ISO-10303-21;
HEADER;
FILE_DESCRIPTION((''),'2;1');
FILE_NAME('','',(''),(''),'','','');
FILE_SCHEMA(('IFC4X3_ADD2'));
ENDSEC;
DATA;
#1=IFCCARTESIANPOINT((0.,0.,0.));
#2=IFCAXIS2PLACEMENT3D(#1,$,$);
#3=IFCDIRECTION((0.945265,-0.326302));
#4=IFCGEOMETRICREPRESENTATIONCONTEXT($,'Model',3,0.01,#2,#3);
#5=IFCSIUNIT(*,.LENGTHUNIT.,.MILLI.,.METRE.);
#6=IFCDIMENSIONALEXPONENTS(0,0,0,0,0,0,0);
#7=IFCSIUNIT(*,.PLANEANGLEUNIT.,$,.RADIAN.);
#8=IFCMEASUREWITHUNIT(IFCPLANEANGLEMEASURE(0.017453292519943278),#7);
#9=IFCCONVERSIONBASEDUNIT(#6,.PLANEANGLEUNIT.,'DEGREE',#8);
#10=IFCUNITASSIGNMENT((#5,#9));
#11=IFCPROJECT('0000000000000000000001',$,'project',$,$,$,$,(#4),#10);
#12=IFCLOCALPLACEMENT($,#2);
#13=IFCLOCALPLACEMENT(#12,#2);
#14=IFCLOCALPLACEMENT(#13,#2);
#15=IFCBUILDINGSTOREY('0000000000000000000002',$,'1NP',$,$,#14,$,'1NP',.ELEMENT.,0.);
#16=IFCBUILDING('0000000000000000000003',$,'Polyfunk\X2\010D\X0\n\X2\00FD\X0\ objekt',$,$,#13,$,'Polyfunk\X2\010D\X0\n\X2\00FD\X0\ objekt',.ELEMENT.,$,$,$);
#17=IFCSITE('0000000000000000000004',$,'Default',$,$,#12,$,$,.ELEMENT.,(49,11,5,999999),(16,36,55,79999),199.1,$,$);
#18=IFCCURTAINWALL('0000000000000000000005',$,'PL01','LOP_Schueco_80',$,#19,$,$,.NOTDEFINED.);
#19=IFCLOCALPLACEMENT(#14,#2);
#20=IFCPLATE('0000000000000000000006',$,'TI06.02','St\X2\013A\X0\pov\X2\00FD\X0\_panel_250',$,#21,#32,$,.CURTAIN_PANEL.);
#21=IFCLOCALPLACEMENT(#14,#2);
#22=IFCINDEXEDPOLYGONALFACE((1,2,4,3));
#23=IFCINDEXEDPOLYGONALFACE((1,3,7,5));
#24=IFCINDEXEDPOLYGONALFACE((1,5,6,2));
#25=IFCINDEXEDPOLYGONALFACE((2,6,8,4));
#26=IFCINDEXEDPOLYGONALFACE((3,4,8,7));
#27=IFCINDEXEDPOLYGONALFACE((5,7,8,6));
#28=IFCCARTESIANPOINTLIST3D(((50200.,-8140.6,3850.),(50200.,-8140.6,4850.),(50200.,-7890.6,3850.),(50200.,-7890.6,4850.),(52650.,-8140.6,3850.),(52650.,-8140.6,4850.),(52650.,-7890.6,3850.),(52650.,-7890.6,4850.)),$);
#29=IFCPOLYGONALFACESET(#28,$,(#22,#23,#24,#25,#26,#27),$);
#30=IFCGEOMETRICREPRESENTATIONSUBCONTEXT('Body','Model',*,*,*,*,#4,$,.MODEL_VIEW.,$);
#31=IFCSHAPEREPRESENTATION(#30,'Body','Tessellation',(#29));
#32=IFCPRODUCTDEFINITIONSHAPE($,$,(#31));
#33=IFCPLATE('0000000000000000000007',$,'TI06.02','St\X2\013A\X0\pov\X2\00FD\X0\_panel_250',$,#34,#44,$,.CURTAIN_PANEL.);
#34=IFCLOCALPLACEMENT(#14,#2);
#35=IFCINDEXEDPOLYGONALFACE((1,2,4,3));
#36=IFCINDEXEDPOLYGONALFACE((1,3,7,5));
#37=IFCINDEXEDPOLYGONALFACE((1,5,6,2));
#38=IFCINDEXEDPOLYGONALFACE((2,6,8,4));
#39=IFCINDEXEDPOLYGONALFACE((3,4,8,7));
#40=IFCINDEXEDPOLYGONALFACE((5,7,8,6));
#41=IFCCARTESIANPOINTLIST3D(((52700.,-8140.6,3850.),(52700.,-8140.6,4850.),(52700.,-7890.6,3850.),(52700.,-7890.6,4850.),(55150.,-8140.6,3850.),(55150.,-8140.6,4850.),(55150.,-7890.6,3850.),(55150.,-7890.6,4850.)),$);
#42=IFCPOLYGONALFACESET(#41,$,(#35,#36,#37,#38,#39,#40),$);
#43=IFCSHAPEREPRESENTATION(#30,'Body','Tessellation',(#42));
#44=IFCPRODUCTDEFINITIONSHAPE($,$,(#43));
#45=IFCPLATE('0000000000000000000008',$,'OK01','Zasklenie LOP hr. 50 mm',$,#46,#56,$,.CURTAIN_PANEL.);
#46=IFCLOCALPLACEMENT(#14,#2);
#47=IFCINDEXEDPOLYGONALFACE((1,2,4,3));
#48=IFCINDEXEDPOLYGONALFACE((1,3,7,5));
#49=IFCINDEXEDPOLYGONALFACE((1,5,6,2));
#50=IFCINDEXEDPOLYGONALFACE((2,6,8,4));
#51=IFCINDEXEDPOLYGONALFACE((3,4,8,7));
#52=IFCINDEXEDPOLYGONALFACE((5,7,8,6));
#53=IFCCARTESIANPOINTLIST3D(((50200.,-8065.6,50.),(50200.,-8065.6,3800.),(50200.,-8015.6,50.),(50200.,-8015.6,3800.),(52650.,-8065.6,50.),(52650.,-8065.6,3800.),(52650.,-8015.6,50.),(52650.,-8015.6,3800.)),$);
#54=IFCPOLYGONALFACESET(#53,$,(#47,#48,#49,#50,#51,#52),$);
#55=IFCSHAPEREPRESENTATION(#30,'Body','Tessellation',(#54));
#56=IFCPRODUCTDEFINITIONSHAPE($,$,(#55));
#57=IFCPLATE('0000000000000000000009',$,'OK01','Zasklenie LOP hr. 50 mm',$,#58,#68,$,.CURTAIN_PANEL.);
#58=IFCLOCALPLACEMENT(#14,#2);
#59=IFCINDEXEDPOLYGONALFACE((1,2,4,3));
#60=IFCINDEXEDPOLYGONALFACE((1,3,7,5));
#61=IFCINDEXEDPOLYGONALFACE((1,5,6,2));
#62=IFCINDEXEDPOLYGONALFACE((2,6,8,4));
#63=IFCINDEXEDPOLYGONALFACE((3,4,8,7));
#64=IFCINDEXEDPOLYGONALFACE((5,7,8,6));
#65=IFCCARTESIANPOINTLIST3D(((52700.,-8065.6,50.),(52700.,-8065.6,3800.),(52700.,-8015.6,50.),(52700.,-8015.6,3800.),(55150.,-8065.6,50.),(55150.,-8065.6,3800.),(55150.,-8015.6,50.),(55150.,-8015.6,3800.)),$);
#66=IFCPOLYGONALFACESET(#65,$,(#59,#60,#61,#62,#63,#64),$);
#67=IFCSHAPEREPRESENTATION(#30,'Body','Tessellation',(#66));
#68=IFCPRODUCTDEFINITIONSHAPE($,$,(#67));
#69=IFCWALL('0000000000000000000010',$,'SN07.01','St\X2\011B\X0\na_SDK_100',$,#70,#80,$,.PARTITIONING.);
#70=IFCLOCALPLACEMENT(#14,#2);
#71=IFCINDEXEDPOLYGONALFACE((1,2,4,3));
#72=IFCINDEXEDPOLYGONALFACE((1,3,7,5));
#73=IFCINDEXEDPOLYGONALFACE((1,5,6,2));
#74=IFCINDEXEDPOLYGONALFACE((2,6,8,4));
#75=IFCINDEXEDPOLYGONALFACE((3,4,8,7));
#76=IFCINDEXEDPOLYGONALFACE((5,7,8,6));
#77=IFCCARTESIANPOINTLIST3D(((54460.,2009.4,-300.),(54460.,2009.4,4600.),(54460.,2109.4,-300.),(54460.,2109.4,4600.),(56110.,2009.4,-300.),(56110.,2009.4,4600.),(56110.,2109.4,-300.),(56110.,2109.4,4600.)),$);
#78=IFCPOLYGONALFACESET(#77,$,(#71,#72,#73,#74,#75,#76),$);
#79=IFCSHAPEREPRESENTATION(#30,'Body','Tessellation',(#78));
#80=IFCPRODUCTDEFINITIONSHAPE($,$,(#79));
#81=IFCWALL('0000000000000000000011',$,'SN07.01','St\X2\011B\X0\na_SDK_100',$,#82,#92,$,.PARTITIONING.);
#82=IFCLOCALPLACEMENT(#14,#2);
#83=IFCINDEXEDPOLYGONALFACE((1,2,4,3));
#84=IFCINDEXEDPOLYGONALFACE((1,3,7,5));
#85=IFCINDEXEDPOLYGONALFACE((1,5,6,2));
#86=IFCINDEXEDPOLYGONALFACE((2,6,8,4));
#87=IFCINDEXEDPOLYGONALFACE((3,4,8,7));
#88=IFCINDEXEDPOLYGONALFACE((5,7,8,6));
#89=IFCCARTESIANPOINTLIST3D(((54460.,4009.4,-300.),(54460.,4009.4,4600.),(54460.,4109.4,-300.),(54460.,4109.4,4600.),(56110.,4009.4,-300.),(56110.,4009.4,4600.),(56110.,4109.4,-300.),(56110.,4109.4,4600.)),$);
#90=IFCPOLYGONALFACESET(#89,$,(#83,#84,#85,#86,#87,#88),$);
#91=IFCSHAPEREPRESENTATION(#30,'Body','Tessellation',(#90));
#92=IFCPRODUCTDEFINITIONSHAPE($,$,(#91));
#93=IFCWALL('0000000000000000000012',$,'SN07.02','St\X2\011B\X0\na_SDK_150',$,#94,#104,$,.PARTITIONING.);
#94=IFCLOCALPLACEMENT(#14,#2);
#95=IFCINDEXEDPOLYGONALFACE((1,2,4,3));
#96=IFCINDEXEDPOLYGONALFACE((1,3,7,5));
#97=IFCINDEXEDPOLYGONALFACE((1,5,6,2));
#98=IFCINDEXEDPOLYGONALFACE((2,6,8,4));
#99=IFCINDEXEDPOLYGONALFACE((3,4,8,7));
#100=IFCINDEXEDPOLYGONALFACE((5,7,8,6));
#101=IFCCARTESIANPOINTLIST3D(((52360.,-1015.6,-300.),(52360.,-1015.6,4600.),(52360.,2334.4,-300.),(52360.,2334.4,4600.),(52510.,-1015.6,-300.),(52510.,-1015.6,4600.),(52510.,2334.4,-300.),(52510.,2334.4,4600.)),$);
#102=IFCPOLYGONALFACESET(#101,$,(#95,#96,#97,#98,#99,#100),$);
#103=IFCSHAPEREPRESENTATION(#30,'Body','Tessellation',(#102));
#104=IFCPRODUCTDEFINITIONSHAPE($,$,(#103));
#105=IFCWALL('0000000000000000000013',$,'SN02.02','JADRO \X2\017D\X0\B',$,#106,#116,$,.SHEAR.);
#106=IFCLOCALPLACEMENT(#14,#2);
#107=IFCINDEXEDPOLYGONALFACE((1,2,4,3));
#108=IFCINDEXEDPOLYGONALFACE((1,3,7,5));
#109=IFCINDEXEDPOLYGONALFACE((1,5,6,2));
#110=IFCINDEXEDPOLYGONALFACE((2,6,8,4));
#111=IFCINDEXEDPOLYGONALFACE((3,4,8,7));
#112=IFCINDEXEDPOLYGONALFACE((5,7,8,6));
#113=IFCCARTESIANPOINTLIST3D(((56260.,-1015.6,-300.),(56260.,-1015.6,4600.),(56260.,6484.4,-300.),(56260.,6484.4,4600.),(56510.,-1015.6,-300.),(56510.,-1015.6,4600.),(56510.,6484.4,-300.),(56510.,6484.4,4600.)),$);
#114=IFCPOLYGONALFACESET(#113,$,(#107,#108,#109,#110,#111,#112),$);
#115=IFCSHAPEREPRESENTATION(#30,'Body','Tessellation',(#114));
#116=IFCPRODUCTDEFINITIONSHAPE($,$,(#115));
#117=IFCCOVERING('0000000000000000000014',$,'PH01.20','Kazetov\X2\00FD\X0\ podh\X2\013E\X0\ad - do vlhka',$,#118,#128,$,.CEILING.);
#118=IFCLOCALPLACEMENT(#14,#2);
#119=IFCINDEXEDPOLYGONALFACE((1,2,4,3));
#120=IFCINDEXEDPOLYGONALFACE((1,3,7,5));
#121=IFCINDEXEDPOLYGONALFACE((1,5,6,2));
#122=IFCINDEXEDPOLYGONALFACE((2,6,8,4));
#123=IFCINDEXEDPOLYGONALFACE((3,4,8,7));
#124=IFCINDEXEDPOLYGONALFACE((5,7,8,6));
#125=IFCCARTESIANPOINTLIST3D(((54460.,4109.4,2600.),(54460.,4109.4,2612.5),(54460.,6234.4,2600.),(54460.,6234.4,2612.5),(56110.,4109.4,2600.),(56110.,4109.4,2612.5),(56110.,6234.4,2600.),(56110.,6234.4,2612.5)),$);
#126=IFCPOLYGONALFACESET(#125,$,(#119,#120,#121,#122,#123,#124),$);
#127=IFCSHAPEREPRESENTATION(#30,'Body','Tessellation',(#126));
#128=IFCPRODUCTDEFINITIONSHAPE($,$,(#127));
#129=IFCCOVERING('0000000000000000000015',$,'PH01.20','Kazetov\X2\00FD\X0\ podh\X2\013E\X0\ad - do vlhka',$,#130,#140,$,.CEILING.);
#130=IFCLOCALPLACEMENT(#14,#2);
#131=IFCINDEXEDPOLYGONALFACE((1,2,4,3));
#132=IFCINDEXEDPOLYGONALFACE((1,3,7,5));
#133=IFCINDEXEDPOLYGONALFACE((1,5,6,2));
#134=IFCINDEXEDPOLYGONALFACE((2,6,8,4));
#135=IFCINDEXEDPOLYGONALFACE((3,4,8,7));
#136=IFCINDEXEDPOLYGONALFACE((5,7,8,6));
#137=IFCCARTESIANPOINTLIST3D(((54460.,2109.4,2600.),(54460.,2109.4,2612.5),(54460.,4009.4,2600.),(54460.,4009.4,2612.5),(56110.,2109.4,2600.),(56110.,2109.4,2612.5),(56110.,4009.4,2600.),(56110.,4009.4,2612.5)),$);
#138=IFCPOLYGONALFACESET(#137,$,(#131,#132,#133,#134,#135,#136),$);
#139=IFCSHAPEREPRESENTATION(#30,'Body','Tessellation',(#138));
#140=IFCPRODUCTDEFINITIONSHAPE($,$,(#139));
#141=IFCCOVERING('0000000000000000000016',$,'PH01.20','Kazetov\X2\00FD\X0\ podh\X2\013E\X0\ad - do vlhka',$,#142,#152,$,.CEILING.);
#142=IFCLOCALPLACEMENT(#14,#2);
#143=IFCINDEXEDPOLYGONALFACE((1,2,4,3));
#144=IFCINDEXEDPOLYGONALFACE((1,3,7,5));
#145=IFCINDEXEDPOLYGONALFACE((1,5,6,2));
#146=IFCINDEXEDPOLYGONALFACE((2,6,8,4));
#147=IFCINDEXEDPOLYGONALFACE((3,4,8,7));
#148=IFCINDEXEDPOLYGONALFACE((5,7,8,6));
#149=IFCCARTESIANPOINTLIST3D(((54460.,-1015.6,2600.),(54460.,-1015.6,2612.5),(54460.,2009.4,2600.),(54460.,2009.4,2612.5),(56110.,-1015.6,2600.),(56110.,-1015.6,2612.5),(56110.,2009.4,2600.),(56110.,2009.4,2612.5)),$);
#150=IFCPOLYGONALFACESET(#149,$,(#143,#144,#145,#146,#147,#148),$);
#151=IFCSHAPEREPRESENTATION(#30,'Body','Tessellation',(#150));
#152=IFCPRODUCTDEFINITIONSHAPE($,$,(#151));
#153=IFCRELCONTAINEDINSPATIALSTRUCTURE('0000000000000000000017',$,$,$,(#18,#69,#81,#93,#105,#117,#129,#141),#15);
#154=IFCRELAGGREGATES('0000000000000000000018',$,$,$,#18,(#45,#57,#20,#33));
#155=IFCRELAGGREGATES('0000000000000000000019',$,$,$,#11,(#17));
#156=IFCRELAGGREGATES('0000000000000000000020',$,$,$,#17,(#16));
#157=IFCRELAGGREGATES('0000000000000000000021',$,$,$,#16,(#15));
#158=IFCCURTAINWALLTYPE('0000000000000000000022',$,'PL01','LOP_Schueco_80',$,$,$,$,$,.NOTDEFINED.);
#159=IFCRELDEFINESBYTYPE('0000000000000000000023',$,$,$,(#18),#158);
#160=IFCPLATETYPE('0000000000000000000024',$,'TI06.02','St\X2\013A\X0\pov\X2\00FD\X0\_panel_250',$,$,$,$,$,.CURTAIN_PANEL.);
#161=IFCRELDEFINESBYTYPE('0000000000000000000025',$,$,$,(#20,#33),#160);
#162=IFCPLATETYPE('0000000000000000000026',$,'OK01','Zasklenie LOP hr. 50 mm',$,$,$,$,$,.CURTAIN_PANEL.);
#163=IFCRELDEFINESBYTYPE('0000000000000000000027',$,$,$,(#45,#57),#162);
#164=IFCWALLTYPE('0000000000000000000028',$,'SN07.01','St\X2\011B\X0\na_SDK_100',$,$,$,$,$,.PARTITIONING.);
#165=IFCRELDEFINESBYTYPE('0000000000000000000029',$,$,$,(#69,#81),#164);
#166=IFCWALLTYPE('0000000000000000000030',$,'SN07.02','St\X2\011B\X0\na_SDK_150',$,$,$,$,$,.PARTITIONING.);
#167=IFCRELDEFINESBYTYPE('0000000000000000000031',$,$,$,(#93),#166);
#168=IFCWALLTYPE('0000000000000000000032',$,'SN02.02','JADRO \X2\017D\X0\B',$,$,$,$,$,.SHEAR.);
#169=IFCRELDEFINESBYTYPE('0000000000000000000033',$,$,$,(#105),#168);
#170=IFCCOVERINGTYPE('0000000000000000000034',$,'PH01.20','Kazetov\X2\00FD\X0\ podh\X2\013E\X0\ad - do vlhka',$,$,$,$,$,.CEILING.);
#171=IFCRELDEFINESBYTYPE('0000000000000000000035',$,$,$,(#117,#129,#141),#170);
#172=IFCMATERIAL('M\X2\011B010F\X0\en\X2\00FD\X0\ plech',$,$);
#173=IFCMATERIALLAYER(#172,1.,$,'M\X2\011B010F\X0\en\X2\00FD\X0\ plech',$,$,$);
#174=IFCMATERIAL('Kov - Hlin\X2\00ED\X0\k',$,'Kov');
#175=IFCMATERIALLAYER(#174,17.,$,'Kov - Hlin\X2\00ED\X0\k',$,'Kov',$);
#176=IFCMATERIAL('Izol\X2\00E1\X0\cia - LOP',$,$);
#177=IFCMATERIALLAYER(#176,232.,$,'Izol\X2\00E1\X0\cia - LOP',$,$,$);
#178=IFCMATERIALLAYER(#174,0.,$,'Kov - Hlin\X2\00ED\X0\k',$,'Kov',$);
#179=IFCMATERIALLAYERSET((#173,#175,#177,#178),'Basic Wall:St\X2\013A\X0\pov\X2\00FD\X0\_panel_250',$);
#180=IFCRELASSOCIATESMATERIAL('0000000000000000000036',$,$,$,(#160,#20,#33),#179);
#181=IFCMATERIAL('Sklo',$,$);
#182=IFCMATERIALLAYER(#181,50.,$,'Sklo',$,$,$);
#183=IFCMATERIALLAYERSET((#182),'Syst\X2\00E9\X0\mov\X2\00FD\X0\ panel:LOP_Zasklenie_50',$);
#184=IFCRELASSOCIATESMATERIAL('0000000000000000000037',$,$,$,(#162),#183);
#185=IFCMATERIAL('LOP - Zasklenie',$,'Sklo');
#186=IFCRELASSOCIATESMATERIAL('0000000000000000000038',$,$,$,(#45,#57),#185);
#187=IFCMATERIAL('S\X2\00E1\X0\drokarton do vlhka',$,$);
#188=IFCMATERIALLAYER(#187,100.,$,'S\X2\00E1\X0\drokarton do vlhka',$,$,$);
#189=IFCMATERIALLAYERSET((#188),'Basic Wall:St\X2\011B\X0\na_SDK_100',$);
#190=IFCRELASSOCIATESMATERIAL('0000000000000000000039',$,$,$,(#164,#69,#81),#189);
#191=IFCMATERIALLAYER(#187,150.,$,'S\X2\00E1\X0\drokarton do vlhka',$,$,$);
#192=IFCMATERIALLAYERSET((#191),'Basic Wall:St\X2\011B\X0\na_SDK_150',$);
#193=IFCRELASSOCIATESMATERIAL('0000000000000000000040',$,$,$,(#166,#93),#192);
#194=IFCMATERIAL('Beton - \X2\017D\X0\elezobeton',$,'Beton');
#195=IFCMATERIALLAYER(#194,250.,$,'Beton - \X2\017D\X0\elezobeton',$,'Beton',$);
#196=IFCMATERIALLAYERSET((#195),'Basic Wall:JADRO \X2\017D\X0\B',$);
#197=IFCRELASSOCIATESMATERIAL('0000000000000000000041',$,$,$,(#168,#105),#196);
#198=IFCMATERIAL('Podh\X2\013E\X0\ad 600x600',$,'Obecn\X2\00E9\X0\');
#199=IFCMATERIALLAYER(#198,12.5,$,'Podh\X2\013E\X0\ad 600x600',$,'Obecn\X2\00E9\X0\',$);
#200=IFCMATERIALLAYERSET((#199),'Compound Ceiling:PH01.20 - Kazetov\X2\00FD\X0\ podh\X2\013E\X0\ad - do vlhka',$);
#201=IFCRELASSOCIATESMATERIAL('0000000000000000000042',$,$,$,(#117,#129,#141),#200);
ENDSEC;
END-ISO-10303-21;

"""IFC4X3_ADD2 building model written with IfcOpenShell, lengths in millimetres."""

from ifc_helpers import new_model, entity, si_unit, converted_unit, direction, frame, frame_2d, origin, origin_2d_with_axis, place, context, subcontext, project, spatial, polyline, rectangle, extrude, clip, bounded_halfspace, source, transform, mapped, material, layer, layer_set, layer_usage, type_object, type_shapes, element, aggregate, save


model = new_model("IFC4X3_ADD2")

# Units and contexts
model_context = context("Model", 3, precision=0.01, world=origin(), true_north=direction((0.945265, -0.326302)))
body_context = subcontext(model_context, "Body", "Model", "MODEL_VIEW")
ifc_project = project(units=[si_unit("LENGTHUNIT", "METRE", prefix="MILLI"), converted_unit("PLANEANGLEUNIT", "DEGREE", entity("IfcPlaneAngleMeasure", 0.017453292519943278), si_unit("PLANEANGLEUNIT", "RADIAN"), dimensions=[0, 0, 0, 0, 0, 0, 0])], contexts=[model_context])

# Site, building, storey
site_placement = place(None, origin())
site = spatial("IfcSite", under=ifc_project, at=site_placement, Name="Default", CompositionType="ELEMENT", RefLatitude=(49, 11, 5, 999999), RefLongitude=(16, 36, 55, 79999), RefElevation=199.1)
building_placement = place(site_placement, origin())
building = spatial("IfcBuilding", under=site, at=building_placement, Name="Polyfunkčný objekt", LongName="Polyfunkčný objekt", CompositionType="ELEMENT")
storey_placement = place(building_placement, origin())
storey = spatial("IfcBuildingStorey", under=building, at=storey_placement, Name="1NP", LongName="1NP", CompositionType="ELEMENT", Elevation=0.0)

# Curtain wall, plates
curtain_wall_type = type_object("IfcCurtainWallType", Name="PL01", Description="LOP_Schueco_80", PredefinedType="NOTDEFINED")
curtain_wall_placement = place(storey_placement, origin())
curtain_wall = element("IfcCurtainWall", 1, at=curtain_wall_placement, inside=storey, type_object=curtain_wall_type, Name="PL01", Description="LOP_Schueco_80", PredefinedType="NOTDEFINED")
ifc_material_1 = material(Name="Měďený plech")
ifc_layer_1 = layer(ifc_material_1, 1.0, Name="Měďený plech")
ifc_material_2 = material(Name="Kov - Hliník", Category="Kov")
ifc_layer_2 = layer(ifc_material_2, 17.0, Name="Kov - Hliník", Category="Kov")
ifc_material_3 = material(Name="Izolácia - LOP")
ifc_layer_3 = layer(ifc_material_3, 232.0, Name="Izolácia - LOP")
ifc_layer_4 = layer(ifc_material_2, 0.0, Name="Kov - Hliník", Category="Kov")
ifc_layer_set_1 = layer_set([ifc_layer_1, ifc_layer_2, ifc_layer_3, ifc_layer_4], Name="Basic Wall:Stĺpový_panel_250")
ifc_layer_usage_1 = layer_usage(ifc_layer_set_1, "AXIS2", "POSITIVE", -125.0)
plate_type_1 = type_object("IfcPlateType", Name="TI06.02", Description="Stĺpový_panel_250", PredefinedType="CURTAIN_PANEL", material=ifc_layer_set_1)
plate_1_placement = place(storey_placement, frame((50200.0, -8015.6, 3850.0)))
plate_1 = element("IfcPlate", 2, at=plate_1_placement, type_object=plate_type_1, material=ifc_layer_usage_1, Name="TI06.02", Description="Stĺpový_panel_250", PredefinedType="CURTAIN_PANEL", context=body_context, shape_type="SweptSolid", body=[
    extrude(rectangle(XDim=250.0, YDim=2450.0, at=origin_2d_with_axis()), frame((1225.0, 0.0, 0.0), z_axis=(0.0, 0.0, 1.0), x_axis=(0.0, 1.0, 0.0)), (0.0, 0.0, 1.0), 1000.0),
])
ifc_layer_usage_2 = layer_usage(ifc_layer_set_1, "AXIS2", "POSITIVE", -125.0)
plate_2_placement = place(storey_placement, frame((52700.0, -8015.6, 3850.0)))
plate_2 = element("IfcPlate", 3, at=plate_2_placement, type_object=plate_type_1, material=ifc_layer_usage_2, Name="TI06.02", Description="Stĺpový_panel_250", PredefinedType="CURTAIN_PANEL", context=body_context, shape_type="SweptSolid", body=[
    extrude(rectangle(XDim=250.0, YDim=2450.0, at=frame_2d((0.0, 0.0), x_axis=(1.0, 0.0))), frame((1225.0, 0.0, 0.0), z_axis=(0.0, 0.0, 1.0), x_axis=(0.0, 1.0, 0.0)), (0.0, 0.0, 1.0), 1000.0),
])
ifc_material_4 = material(Name="LOP - Zasklenie", Category="Sklo")
ifc_material_5 = material(Name="Sklo")
ifc_layer_5 = layer(ifc_material_5, 50.0, Name="Sklo")
ifc_layer_set_2 = layer_set([ifc_layer_5], Name="Systémový panel:LOP_Zasklenie_50")
plate_type_2 = type_object("IfcPlateType", Name="OK01", Description="Zasklenie LOP hr. 50 mm", PredefinedType="CURTAIN_PANEL", material=ifc_layer_set_2)
shared_shape_1 = source(origin(), body_context, "Body", "SweptSolid", [
    extrude(rectangle(XDim=3750.0, YDim=2450.0, at=frame_2d((-331.2, 0.0), x_axis=(1.0, 0.0))), frame((0.0, -50.0, 2206.2), z_axis=(0.0, 1.0, 0.0), x_axis=(0.0, 0.0, 1.0)), (0.0, 0.0, 1.0), 50.0),
])
type_shapes(plate_type_2, [shared_shape_1])
plate_3_placement = place(curtain_wall_placement, frame((51425.0, -8015.6, 50.0)))
plate_3 = element("IfcPlate", 4, at=plate_3_placement, type_object=plate_type_2, material=ifc_material_4, Name="OK01", Description="Zasklenie LOP hr. 50 mm", PredefinedType="CURTAIN_PANEL", context=body_context, shape_type="MappedRepresentation", body=[
    mapped(shared_shape_1, transform((0.0, 0.0, 0.0), scale=1.0)),
])
plate_4_placement = place(curtain_wall_placement, frame((53925.0, -8015.6, 50.0)))
plate_4 = element("IfcPlate", 5, at=plate_4_placement, type_object=plate_type_2, material=ifc_material_4, Name="OK01", Description="Zasklenie LOP hr. 50 mm", PredefinedType="CURTAIN_PANEL", context=body_context, shape_type="MappedRepresentation", body=[
    mapped(shared_shape_1, transform((0.0, 0.0, 0.0), scale=1.0)),
])
aggregate(curtain_wall, [plate_3, plate_4, plate_1, plate_2])

# Walls
ifc_material_6 = material(Name="Sádrokarton do vlhka")
ifc_layer_6 = layer(ifc_material_6, 100.0, Name="Sádrokarton do vlhka")
ifc_layer_set_3 = layer_set([ifc_layer_6], Name="Basic Wall:Stěna_SDK_100")
wall_type_1 = type_object("IfcWallType", Name="SN07.01", Description="Stěna_SDK_100", PredefinedType="PARTITIONING", material=ifc_layer_set_3)
wall_1_placement = place(storey_placement, frame((54460.0, 2059.4, -300.0)))
element("IfcWall", 6, at=wall_1_placement, inside=storey, type_object=wall_type_1, material=ifc_layer_set_3, Name="SN07.01", Description="Stěna_SDK_100", PredefinedType="PARTITIONING", context=body_context, shape_type="Clipping", body=[
    clip(clip(extrude(rectangle(XDim=1650.0, YDim=100.0, at=frame_2d((825.0, 0.0), x_axis=(-1.0, 0.0))), origin(), (0.0, 0.0, 1.0), 4900.0), bounded_halfspace(frame((0.0, -50.0, 4900.0), z_axis=(0.0, 0.0, -1.0), x_axis=(1.0, 0.0, 0.0)), True, frame((0.0, -50.0, 4900.0)), polyline([(0.0, 0.0), (1650.0, 0.0), (1650.0, 100.0), (0.0, 100.0), (0.0, 0.0)]))), bounded_halfspace(frame((1650.0, -50.0, 0.0), z_axis=(0.0, 0.0, 1.0), x_axis=(0.0, 1.0, 0.0)), True, frame((1650.0, -50.0, 0.0)), polyline([(0.0, 0.0), (0.0, 100.0), (-1650.0, 100.0), (-1650.0, 0.0), (0.0, 0.0)]))),
])
wall_2_placement = place(storey_placement, frame((54460.0, 4059.4, -300.0)))
element("IfcWall", 7, at=wall_2_placement, inside=storey, type_object=wall_type_1, material=ifc_layer_set_3, Name="SN07.01", Description="Stěna_SDK_100", PredefinedType="PARTITIONING", context=body_context, shape_type="Clipping", body=[
    clip(clip(extrude(rectangle(XDim=1650.0, YDim=100.0, at=frame_2d((825.0, 0.0), x_axis=(-1.0, 0.0))), origin(), (0.0, 0.0, 1.0), 4900.0), bounded_halfspace(frame((0.0, -50.0, 4900.0), z_axis=(0.0, 0.0, -1.0), x_axis=(1.0, 0.0, 0.0)), True, frame((0.0, -50.0, 4900.0)), polyline([(0.0, 0.0), (1650.0, 0.0), (1650.0, 100.0), (0.0, 100.0), (0.0, 0.0)]))), bounded_halfspace(frame((1650.0, -50.0, 0.0), z_axis=(0.0, 0.0, 1.0), x_axis=(0.0, 1.0, 0.0)), True, frame((1650.0, -50.0, 0.0)), polyline([(0.0, 0.0), (0.0, 100.0), (-1650.0, 100.0), (-1650.0, 0.0), (0.0, 0.0)]))),
])
ifc_layer_7 = layer(ifc_material_6, 150.0, Name="Sádrokarton do vlhka")
ifc_layer_set_4 = layer_set([ifc_layer_7], Name="Basic Wall:Stěna_SDK_150")
wall_type_2 = type_object("IfcWallType", Name="SN07.02", Description="Stěna_SDK_150", PredefinedType="PARTITIONING", material=ifc_layer_set_4)
wall_3_placement = place(storey_placement, frame((52435.0, 2334.4, -300.0), z_axis=(0.0, 0.0, 1.0), x_axis=(0.0, -1.0, 0.0)))
element("IfcWall", 8, at=wall_3_placement, inside=storey, type_object=wall_type_2, material=ifc_layer_set_4, Name="SN07.02", Description="Stěna_SDK_150", PredefinedType="PARTITIONING", context=body_context, shape_type="Clipping", body=[
    clip(clip(extrude(rectangle(XDim=3350.0, YDim=150.0, at=frame_2d((1675.0, 0.0), x_axis=(-1.0, 0.0))), origin(), (0.0, 0.0, 1.0), 4900.0), bounded_halfspace(frame((3350.0, -75.0, 0.0), z_axis=(0.0, 0.0, 1.0), x_axis=(-1.0, 0.0, 0.0)), True, frame((3350.0, -75.0, 0.0)), polyline([(0.0, 0.0), (0.0, 150.0), (-3350.0, 150.0), (-3350.0, 0.0), (0.0, 0.0)]))), bounded_halfspace(frame((0.0, -75.0, 4900.0), z_axis=(0.0, 0.0, -1.0), x_axis=(0.0, 1.0, 0.0)), True, frame((0.0, -75.0, 4900.0)), polyline([(0.0, 0.0), (3350.0, 0.0), (3350.0, 150.0), (0.0, 150.0), (0.0, 0.0)]))),
])
ifc_material_7 = material(Name="Beton - Železobeton", Category="Beton")
ifc_layer_8 = layer(ifc_material_7, 250.0, Name="Beton - Železobeton", Category="Beton")
ifc_layer_set_5 = layer_set([ifc_layer_8], Name="Basic Wall:JADRO ŽB")
wall_type_3 = type_object("IfcWallType", Name="SN02.02", Description="JADRO ŽB", PredefinedType="SHEAR", material=ifc_layer_set_5)
wall_4_placement = place(storey_placement, frame((56385.0, -1015.6, -300.0), z_axis=(0.0, 0.0, 1.0), x_axis=(0.0, 1.0, 0.0)))
element("IfcWall", 9, at=wall_4_placement, inside=storey, type_object=wall_type_3, material=ifc_layer_set_5, Name="SN02.02", Description="JADRO ŽB", PredefinedType="SHEAR", context=body_context, shape_type="Clipping", body=[
    clip(clip(extrude(rectangle(XDim=7500.0, YDim=250.0, at=frame_2d((3750.0, 0.0), x_axis=(-1.0, 0.0))), origin(), (0.0, 0.0, 1.0), 4900.0), bounded_halfspace(frame((0.0, -125.0, 4900.0), z_axis=(0.0, 0.0, -1.0), x_axis=(0.0, -1.0, 0.0)), True, frame((0.0, -125.0, 4900.0)), polyline([(0.0, 0.0), (7500.0, 0.0), (7500.0, 250.0), (7250.0, 250.0), (0.0, 250.0), (0.0, 0.0)]))), bounded_halfspace(frame((0.0, -125.0, 0.0)), True, frame((0.0, -125.0, 0.0)), polyline([(0.0, 0.0), (7110.0, 0.0), (7500.0, 0.0), (7500.0, 250.0), (7250.0, 250.0), (0.0, 250.0), (0.0, 0.0)]))),
])

# Shared definitions
ifc_material_8 = material(Name="Podhľad 600x600", Category="Obecné")

# Coverings
ifc_layer_9 = layer(ifc_material_8, 12.5, Name="Podhľad 600x600", Category="Obecné")
ifc_layer_set_6 = layer_set([ifc_layer_9], Name="Compound Ceiling:PH01.20 - Kazetový podhľad - do vlhka")
ifc_layer_usage_3 = layer_usage(ifc_layer_set_6, "AXIS3", "NEGATIVE", 0.0)
covering_type_1 = type_object("IfcCoveringType", Name="PH01.20", Description="Kazetový podhľad - do vlhka", PredefinedType="CEILING")
covering_1_placement = place(storey_placement, frame((54460.0, 4109.4, 2600.0)))
element("IfcCovering", 10, at=covering_1_placement, inside=storey, type_object=covering_type_1, material=ifc_layer_usage_3, Name="PH01.20", Description="Kazetový podhľad - do vlhka", PredefinedType="CEILING", context=body_context, shape_type="SweptSolid", body=[
    extrude(rectangle(XDim=2125.0, YDim=1650.0, at=frame_2d((0.0, 0.0), x_axis=(1.0, 0.0))), frame((825.0, 1062.5, 0.0), z_axis=(0.0, 0.0, 1.0), x_axis=(0.0, -1.0, 0.0)), (0.0, 0.0, 1.0), 12.5),
])
ifc_layer_usage_4 = layer_usage(ifc_layer_set_6, "AXIS3", "NEGATIVE", 0.0)
covering_2_placement = place(storey_placement, frame((54460.0, 2109.4, 2600.0)))
element("IfcCovering", 11, at=covering_2_placement, inside=storey, type_object=covering_type_1, material=ifc_layer_usage_4, Name="PH01.20", Description="Kazetový podhľad - do vlhka", PredefinedType="CEILING", context=body_context, shape_type="SweptSolid", body=[
    extrude(rectangle(XDim=1900.0, YDim=1650.0, at=frame_2d((0.0, 0.0), x_axis=(1.0, 0.0))), frame((825.0, 950.0, 0.0), z_axis=(0.0, 0.0, 1.0), x_axis=(0.0, 1.0, 0.0)), (0.0, 0.0, 1.0), 12.5),
])
ifc_layer_usage_5 = layer_usage(ifc_layer_set_6, "AXIS3", "NEGATIVE", 0.0)
covering_3_placement = place(storey_placement, frame((54460.0, -1015.6, 2600.0)))
element("IfcCovering", 12, at=covering_3_placement, inside=storey, type_object=covering_type_1, material=ifc_layer_usage_5, Name="PH01.20", Description="Kazetový podhľad - do vlhka", PredefinedType="CEILING", context=body_context, shape_type="SweptSolid", body=[
    extrude(rectangle(XDim=1650.0, YDim=3025.0, at=frame_2d((0.0, 0.0), x_axis=(1.0, 0.0))), frame((825.0, 1512.5, 0.0), z_axis=(0.0, 0.0, 1.0), x_axis=(-1.0, 0.0, 0.0)), (0.0, 0.0, 1.0), 12.5),
])

save(model, "model.ifc")
